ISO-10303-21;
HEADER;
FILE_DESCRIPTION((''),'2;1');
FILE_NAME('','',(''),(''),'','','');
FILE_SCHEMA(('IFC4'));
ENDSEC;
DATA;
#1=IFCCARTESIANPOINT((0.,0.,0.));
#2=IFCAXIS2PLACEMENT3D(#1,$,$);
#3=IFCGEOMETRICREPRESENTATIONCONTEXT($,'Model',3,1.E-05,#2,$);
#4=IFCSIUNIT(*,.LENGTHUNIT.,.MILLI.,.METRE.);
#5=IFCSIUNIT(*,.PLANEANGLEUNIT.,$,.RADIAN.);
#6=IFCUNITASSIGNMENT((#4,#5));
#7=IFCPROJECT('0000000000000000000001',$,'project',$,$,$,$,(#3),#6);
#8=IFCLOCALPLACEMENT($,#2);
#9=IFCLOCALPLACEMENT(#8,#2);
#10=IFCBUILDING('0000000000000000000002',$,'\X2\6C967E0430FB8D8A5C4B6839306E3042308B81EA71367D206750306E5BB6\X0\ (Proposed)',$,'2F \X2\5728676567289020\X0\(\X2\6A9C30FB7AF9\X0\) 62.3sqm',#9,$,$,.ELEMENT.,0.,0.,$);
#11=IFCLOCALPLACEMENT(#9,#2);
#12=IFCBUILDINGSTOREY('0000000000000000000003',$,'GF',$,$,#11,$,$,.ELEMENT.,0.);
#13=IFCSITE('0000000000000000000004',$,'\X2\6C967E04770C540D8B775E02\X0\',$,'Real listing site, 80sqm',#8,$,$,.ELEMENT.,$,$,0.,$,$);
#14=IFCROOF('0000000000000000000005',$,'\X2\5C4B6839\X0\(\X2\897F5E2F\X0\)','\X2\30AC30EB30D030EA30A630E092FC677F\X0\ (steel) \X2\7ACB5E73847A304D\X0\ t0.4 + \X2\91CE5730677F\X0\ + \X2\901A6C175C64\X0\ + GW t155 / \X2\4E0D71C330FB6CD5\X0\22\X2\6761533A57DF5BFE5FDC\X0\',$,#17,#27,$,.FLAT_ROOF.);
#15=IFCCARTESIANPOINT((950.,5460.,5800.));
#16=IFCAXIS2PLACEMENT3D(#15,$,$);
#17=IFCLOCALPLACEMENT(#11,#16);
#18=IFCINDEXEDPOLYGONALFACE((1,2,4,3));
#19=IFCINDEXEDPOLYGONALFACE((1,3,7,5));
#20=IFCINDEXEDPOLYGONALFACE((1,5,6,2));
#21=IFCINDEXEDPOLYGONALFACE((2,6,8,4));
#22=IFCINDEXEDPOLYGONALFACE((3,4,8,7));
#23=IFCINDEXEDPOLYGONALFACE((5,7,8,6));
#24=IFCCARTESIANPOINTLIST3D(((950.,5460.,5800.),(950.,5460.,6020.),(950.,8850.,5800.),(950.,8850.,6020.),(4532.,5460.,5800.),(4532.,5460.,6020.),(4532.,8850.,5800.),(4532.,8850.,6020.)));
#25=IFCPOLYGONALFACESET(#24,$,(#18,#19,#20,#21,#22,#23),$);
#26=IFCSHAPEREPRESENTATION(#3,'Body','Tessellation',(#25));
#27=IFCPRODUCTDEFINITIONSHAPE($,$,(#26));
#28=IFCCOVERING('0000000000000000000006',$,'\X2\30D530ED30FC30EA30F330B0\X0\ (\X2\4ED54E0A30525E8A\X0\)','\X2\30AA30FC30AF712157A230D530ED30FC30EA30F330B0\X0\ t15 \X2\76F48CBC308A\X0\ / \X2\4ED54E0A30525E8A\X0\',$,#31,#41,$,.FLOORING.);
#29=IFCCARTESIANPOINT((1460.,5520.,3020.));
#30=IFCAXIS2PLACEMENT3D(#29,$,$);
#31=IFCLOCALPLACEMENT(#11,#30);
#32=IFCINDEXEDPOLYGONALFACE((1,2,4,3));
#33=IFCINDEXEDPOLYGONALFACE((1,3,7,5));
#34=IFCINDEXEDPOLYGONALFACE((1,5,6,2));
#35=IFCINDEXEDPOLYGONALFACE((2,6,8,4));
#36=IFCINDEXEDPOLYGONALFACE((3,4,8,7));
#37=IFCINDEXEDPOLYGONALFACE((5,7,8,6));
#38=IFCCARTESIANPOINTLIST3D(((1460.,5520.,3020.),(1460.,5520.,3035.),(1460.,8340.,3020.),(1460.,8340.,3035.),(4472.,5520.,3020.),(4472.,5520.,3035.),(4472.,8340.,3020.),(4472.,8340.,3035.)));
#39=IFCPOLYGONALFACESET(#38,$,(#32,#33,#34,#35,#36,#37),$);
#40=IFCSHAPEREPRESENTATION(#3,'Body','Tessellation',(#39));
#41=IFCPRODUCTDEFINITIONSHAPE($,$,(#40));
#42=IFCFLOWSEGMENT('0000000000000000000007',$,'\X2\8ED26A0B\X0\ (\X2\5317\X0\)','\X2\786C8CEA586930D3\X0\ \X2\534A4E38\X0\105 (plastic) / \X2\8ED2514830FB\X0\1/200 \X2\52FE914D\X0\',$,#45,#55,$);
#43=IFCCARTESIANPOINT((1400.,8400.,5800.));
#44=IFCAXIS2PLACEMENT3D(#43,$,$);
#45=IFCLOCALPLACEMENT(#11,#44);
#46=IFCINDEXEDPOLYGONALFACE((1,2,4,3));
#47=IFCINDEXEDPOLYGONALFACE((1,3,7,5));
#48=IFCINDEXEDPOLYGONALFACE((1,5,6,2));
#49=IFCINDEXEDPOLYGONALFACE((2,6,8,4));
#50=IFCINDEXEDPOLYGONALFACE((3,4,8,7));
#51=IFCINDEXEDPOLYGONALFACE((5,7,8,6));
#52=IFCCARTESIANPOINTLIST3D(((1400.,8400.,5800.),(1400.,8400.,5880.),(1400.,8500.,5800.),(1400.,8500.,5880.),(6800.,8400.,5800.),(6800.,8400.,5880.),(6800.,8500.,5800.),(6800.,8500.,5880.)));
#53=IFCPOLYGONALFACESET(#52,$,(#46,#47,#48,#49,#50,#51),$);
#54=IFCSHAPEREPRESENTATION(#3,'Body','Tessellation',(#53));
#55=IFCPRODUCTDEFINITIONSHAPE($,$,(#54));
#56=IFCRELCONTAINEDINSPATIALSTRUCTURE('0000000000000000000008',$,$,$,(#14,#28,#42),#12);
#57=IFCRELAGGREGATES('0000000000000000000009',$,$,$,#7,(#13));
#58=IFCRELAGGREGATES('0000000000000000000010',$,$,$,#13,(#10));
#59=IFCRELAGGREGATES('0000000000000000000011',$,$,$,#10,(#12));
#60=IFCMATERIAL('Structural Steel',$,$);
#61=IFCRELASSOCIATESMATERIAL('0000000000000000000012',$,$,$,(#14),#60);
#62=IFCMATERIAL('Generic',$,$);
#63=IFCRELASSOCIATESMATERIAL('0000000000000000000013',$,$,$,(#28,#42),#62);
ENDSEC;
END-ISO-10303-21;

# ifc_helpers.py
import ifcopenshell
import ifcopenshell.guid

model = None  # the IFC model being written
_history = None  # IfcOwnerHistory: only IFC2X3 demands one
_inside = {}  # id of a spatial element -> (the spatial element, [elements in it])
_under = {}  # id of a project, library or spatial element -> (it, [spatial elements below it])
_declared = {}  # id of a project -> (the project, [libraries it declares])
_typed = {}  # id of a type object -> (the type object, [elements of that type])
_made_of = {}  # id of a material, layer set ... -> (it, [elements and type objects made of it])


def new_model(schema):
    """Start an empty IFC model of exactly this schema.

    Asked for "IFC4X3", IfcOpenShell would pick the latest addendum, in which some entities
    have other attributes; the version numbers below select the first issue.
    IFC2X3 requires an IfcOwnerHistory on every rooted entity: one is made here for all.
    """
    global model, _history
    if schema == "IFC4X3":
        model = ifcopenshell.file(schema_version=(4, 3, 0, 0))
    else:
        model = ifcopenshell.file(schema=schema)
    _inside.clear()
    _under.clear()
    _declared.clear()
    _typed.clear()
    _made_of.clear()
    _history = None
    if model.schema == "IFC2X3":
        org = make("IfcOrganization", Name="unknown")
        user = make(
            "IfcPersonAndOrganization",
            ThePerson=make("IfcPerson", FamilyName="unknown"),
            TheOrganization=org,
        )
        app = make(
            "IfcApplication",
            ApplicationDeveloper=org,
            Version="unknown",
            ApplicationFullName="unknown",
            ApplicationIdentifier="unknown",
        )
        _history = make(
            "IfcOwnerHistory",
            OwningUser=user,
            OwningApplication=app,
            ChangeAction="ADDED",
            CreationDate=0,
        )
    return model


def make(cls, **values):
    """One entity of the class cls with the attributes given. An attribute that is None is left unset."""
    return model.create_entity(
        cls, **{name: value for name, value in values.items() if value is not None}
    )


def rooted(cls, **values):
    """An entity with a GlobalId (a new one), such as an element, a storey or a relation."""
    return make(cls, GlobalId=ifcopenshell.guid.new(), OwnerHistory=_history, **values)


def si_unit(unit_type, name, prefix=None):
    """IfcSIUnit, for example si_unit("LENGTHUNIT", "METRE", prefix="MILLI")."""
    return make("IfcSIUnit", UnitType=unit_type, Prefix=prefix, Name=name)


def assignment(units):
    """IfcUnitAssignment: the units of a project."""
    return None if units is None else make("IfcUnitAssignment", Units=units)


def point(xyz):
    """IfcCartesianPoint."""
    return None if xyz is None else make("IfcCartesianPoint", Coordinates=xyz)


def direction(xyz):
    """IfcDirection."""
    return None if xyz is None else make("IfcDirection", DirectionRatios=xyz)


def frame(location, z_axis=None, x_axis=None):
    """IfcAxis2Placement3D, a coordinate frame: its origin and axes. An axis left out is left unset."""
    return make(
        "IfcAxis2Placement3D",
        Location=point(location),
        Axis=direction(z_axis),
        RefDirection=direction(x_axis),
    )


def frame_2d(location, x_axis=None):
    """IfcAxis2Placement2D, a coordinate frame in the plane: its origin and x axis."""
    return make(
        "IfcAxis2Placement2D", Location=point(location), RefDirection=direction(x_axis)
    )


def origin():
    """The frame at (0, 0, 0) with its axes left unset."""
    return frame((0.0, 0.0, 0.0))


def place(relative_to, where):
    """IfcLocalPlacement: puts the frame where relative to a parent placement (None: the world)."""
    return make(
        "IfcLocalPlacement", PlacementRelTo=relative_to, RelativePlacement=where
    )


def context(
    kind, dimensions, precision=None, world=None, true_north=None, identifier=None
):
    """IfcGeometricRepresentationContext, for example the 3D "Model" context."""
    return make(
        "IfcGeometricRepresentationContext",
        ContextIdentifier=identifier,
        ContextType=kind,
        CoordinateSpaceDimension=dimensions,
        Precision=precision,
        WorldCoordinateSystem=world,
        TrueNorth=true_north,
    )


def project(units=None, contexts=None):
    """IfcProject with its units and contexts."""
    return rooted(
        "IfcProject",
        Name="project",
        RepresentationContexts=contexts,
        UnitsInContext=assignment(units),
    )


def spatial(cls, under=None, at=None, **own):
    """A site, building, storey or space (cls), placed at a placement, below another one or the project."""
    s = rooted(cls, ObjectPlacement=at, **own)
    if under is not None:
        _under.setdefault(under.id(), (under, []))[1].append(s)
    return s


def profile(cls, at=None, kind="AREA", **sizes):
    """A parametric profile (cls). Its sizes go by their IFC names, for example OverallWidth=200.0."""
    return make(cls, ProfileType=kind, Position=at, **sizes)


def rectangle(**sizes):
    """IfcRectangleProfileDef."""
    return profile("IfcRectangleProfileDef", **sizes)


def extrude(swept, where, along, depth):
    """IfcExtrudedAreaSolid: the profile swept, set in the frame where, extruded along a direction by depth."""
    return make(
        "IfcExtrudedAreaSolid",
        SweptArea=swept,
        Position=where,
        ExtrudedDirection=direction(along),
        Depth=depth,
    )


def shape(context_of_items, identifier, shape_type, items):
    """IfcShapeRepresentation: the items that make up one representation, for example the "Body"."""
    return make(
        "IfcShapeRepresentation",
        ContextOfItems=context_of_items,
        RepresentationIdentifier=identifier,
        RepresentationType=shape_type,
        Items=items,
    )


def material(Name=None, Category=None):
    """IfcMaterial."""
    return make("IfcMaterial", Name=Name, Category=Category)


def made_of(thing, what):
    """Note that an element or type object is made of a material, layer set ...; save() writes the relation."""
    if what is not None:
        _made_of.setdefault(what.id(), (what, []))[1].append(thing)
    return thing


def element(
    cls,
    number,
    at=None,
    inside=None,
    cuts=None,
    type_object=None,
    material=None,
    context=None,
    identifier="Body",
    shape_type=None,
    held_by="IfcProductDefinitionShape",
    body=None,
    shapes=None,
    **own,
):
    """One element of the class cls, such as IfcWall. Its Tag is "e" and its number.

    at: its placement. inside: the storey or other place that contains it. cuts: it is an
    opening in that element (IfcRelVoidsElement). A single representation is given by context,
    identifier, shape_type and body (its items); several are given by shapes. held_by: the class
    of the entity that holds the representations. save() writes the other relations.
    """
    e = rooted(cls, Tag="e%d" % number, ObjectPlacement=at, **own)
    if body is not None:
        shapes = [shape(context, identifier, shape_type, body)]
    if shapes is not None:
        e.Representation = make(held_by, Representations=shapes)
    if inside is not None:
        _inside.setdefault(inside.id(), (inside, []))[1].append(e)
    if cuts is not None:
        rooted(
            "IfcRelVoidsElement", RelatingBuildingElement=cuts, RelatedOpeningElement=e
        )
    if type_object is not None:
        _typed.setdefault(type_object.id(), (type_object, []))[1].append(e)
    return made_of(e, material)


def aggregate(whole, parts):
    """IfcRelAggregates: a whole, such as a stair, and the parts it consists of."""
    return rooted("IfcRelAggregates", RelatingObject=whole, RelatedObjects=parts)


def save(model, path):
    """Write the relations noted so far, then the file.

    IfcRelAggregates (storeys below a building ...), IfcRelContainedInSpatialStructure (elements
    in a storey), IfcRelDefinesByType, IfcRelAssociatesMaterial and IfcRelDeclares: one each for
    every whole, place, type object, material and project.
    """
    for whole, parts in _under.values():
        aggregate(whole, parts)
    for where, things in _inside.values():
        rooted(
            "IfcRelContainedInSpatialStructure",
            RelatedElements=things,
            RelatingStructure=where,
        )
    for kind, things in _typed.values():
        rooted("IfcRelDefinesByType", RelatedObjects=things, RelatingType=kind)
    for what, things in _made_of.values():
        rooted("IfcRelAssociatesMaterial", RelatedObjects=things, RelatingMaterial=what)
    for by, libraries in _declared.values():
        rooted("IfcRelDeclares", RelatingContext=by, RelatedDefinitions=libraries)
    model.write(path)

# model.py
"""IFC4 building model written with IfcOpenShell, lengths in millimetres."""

from ifc_helpers import new_model, si_unit, frame, frame_2d, origin, place, context, project, spatial, rectangle, extrude, material, element, save


model = new_model("IFC4")

# Units and contexts
model_context = context("Model", 3, precision=1e-05, world=origin())
ifc_project = project(units=[si_unit("LENGTHUNIT", "METRE", prefix="MILLI"), si_unit("PLANEANGLEUNIT", "RADIAN")], contexts=[model_context])

# Site, building, storey
site_placement = place(None, origin())
site = spatial("IfcSite", under=ifc_project, at=site_placement, Name="沖縄県名護市", ObjectType="Real listing site, 80sqm", CompositionType="ELEMENT", RefElevation=0.0)
building_placement = place(site_placement, origin())
building = spatial("IfcBuilding", under=site, at=building_placement, Name="沖縄・越屋根のある自然素材の家 (Proposed)", ObjectType="2F 在来木造(檜・竹) 62.3sqm", CompositionType="ELEMENT", ElevationOfRefHeight=0.0, ElevationOfTerrain=0.0)
storey_placement = place(building_placement, origin())
storey = spatial("IfcBuildingStorey", under=building, at=storey_placement, Name="GF", CompositionType="ELEMENT", Elevation=0.0)

# Roof
ifc_material_1 = material(Name="Structural Steel")
for number, where, name in (
    (1, (950.0, 5460.0, 5800.0), "屋根(西帯)"),
):
    element("IfcRoof", number, at=place(storey_placement, frame(where)), inside=storey, material=ifc_material_1, Name=name, Description="ガルバリウム鋼板 (steel) 立平葺き t0.4 + 野地板 + 通気層 + GW t155 / 不燃・法22条区域対応", PredefinedType="FLAT_ROOF", context=model_context, shape_type="SweptSolid", body=[
        extrude(rectangle(XDim=3582.0, YDim=3390.0, at=frame_2d((1791.0, 1695.0))), frame((950.0, 5460.0, 5800.0)), (0.0, 0.0, 1.0), 220.0),
    ])

# Covering
ifc_material_2 = material(Name="Generic")
covering_placement = place(storey_placement, frame((1460.0, 5520.0, 3020.0)))
element("IfcCovering", 2, at=covering_placement, inside=storey, material=ifc_material_2, Name="フローリング (仕上げ床)", Description="オーク無垢フローリング t15 直貼り / 仕上げ床", PredefinedType="FLOORING", context=model_context, shape_type="SweptSolid", body=[
    extrude(rectangle(XDim=3012.0, YDim=2820.0, at=frame_2d((1506.0, 1410.0))), frame((1460.0, 5520.0, 3020.0)), (0.0, 0.0, 1.0), 15.0),
])

# Flow segment
flow_segment_placement = place(storey_placement, frame((1400.0, 8400.0, 5800.0)))
element("IfcFlowSegment", 3, at=flow_segment_placement, inside=storey, material=ifc_material_2, Name="軒樋 (北)", Description="硬質塩ビ 半丸105 (plastic) / 軒先・1/200 勾配", context=model_context, shape_type="SweptSolid", body=[
    extrude(rectangle(XDim=5400.0, YDim=100.0, at=frame_2d((2700.0, 50.0))), frame((1400.0, 8400.0, 5800.0)), (0.0, 0.0, 1.0), 80.0),
])

save(model, "model.ifc")
